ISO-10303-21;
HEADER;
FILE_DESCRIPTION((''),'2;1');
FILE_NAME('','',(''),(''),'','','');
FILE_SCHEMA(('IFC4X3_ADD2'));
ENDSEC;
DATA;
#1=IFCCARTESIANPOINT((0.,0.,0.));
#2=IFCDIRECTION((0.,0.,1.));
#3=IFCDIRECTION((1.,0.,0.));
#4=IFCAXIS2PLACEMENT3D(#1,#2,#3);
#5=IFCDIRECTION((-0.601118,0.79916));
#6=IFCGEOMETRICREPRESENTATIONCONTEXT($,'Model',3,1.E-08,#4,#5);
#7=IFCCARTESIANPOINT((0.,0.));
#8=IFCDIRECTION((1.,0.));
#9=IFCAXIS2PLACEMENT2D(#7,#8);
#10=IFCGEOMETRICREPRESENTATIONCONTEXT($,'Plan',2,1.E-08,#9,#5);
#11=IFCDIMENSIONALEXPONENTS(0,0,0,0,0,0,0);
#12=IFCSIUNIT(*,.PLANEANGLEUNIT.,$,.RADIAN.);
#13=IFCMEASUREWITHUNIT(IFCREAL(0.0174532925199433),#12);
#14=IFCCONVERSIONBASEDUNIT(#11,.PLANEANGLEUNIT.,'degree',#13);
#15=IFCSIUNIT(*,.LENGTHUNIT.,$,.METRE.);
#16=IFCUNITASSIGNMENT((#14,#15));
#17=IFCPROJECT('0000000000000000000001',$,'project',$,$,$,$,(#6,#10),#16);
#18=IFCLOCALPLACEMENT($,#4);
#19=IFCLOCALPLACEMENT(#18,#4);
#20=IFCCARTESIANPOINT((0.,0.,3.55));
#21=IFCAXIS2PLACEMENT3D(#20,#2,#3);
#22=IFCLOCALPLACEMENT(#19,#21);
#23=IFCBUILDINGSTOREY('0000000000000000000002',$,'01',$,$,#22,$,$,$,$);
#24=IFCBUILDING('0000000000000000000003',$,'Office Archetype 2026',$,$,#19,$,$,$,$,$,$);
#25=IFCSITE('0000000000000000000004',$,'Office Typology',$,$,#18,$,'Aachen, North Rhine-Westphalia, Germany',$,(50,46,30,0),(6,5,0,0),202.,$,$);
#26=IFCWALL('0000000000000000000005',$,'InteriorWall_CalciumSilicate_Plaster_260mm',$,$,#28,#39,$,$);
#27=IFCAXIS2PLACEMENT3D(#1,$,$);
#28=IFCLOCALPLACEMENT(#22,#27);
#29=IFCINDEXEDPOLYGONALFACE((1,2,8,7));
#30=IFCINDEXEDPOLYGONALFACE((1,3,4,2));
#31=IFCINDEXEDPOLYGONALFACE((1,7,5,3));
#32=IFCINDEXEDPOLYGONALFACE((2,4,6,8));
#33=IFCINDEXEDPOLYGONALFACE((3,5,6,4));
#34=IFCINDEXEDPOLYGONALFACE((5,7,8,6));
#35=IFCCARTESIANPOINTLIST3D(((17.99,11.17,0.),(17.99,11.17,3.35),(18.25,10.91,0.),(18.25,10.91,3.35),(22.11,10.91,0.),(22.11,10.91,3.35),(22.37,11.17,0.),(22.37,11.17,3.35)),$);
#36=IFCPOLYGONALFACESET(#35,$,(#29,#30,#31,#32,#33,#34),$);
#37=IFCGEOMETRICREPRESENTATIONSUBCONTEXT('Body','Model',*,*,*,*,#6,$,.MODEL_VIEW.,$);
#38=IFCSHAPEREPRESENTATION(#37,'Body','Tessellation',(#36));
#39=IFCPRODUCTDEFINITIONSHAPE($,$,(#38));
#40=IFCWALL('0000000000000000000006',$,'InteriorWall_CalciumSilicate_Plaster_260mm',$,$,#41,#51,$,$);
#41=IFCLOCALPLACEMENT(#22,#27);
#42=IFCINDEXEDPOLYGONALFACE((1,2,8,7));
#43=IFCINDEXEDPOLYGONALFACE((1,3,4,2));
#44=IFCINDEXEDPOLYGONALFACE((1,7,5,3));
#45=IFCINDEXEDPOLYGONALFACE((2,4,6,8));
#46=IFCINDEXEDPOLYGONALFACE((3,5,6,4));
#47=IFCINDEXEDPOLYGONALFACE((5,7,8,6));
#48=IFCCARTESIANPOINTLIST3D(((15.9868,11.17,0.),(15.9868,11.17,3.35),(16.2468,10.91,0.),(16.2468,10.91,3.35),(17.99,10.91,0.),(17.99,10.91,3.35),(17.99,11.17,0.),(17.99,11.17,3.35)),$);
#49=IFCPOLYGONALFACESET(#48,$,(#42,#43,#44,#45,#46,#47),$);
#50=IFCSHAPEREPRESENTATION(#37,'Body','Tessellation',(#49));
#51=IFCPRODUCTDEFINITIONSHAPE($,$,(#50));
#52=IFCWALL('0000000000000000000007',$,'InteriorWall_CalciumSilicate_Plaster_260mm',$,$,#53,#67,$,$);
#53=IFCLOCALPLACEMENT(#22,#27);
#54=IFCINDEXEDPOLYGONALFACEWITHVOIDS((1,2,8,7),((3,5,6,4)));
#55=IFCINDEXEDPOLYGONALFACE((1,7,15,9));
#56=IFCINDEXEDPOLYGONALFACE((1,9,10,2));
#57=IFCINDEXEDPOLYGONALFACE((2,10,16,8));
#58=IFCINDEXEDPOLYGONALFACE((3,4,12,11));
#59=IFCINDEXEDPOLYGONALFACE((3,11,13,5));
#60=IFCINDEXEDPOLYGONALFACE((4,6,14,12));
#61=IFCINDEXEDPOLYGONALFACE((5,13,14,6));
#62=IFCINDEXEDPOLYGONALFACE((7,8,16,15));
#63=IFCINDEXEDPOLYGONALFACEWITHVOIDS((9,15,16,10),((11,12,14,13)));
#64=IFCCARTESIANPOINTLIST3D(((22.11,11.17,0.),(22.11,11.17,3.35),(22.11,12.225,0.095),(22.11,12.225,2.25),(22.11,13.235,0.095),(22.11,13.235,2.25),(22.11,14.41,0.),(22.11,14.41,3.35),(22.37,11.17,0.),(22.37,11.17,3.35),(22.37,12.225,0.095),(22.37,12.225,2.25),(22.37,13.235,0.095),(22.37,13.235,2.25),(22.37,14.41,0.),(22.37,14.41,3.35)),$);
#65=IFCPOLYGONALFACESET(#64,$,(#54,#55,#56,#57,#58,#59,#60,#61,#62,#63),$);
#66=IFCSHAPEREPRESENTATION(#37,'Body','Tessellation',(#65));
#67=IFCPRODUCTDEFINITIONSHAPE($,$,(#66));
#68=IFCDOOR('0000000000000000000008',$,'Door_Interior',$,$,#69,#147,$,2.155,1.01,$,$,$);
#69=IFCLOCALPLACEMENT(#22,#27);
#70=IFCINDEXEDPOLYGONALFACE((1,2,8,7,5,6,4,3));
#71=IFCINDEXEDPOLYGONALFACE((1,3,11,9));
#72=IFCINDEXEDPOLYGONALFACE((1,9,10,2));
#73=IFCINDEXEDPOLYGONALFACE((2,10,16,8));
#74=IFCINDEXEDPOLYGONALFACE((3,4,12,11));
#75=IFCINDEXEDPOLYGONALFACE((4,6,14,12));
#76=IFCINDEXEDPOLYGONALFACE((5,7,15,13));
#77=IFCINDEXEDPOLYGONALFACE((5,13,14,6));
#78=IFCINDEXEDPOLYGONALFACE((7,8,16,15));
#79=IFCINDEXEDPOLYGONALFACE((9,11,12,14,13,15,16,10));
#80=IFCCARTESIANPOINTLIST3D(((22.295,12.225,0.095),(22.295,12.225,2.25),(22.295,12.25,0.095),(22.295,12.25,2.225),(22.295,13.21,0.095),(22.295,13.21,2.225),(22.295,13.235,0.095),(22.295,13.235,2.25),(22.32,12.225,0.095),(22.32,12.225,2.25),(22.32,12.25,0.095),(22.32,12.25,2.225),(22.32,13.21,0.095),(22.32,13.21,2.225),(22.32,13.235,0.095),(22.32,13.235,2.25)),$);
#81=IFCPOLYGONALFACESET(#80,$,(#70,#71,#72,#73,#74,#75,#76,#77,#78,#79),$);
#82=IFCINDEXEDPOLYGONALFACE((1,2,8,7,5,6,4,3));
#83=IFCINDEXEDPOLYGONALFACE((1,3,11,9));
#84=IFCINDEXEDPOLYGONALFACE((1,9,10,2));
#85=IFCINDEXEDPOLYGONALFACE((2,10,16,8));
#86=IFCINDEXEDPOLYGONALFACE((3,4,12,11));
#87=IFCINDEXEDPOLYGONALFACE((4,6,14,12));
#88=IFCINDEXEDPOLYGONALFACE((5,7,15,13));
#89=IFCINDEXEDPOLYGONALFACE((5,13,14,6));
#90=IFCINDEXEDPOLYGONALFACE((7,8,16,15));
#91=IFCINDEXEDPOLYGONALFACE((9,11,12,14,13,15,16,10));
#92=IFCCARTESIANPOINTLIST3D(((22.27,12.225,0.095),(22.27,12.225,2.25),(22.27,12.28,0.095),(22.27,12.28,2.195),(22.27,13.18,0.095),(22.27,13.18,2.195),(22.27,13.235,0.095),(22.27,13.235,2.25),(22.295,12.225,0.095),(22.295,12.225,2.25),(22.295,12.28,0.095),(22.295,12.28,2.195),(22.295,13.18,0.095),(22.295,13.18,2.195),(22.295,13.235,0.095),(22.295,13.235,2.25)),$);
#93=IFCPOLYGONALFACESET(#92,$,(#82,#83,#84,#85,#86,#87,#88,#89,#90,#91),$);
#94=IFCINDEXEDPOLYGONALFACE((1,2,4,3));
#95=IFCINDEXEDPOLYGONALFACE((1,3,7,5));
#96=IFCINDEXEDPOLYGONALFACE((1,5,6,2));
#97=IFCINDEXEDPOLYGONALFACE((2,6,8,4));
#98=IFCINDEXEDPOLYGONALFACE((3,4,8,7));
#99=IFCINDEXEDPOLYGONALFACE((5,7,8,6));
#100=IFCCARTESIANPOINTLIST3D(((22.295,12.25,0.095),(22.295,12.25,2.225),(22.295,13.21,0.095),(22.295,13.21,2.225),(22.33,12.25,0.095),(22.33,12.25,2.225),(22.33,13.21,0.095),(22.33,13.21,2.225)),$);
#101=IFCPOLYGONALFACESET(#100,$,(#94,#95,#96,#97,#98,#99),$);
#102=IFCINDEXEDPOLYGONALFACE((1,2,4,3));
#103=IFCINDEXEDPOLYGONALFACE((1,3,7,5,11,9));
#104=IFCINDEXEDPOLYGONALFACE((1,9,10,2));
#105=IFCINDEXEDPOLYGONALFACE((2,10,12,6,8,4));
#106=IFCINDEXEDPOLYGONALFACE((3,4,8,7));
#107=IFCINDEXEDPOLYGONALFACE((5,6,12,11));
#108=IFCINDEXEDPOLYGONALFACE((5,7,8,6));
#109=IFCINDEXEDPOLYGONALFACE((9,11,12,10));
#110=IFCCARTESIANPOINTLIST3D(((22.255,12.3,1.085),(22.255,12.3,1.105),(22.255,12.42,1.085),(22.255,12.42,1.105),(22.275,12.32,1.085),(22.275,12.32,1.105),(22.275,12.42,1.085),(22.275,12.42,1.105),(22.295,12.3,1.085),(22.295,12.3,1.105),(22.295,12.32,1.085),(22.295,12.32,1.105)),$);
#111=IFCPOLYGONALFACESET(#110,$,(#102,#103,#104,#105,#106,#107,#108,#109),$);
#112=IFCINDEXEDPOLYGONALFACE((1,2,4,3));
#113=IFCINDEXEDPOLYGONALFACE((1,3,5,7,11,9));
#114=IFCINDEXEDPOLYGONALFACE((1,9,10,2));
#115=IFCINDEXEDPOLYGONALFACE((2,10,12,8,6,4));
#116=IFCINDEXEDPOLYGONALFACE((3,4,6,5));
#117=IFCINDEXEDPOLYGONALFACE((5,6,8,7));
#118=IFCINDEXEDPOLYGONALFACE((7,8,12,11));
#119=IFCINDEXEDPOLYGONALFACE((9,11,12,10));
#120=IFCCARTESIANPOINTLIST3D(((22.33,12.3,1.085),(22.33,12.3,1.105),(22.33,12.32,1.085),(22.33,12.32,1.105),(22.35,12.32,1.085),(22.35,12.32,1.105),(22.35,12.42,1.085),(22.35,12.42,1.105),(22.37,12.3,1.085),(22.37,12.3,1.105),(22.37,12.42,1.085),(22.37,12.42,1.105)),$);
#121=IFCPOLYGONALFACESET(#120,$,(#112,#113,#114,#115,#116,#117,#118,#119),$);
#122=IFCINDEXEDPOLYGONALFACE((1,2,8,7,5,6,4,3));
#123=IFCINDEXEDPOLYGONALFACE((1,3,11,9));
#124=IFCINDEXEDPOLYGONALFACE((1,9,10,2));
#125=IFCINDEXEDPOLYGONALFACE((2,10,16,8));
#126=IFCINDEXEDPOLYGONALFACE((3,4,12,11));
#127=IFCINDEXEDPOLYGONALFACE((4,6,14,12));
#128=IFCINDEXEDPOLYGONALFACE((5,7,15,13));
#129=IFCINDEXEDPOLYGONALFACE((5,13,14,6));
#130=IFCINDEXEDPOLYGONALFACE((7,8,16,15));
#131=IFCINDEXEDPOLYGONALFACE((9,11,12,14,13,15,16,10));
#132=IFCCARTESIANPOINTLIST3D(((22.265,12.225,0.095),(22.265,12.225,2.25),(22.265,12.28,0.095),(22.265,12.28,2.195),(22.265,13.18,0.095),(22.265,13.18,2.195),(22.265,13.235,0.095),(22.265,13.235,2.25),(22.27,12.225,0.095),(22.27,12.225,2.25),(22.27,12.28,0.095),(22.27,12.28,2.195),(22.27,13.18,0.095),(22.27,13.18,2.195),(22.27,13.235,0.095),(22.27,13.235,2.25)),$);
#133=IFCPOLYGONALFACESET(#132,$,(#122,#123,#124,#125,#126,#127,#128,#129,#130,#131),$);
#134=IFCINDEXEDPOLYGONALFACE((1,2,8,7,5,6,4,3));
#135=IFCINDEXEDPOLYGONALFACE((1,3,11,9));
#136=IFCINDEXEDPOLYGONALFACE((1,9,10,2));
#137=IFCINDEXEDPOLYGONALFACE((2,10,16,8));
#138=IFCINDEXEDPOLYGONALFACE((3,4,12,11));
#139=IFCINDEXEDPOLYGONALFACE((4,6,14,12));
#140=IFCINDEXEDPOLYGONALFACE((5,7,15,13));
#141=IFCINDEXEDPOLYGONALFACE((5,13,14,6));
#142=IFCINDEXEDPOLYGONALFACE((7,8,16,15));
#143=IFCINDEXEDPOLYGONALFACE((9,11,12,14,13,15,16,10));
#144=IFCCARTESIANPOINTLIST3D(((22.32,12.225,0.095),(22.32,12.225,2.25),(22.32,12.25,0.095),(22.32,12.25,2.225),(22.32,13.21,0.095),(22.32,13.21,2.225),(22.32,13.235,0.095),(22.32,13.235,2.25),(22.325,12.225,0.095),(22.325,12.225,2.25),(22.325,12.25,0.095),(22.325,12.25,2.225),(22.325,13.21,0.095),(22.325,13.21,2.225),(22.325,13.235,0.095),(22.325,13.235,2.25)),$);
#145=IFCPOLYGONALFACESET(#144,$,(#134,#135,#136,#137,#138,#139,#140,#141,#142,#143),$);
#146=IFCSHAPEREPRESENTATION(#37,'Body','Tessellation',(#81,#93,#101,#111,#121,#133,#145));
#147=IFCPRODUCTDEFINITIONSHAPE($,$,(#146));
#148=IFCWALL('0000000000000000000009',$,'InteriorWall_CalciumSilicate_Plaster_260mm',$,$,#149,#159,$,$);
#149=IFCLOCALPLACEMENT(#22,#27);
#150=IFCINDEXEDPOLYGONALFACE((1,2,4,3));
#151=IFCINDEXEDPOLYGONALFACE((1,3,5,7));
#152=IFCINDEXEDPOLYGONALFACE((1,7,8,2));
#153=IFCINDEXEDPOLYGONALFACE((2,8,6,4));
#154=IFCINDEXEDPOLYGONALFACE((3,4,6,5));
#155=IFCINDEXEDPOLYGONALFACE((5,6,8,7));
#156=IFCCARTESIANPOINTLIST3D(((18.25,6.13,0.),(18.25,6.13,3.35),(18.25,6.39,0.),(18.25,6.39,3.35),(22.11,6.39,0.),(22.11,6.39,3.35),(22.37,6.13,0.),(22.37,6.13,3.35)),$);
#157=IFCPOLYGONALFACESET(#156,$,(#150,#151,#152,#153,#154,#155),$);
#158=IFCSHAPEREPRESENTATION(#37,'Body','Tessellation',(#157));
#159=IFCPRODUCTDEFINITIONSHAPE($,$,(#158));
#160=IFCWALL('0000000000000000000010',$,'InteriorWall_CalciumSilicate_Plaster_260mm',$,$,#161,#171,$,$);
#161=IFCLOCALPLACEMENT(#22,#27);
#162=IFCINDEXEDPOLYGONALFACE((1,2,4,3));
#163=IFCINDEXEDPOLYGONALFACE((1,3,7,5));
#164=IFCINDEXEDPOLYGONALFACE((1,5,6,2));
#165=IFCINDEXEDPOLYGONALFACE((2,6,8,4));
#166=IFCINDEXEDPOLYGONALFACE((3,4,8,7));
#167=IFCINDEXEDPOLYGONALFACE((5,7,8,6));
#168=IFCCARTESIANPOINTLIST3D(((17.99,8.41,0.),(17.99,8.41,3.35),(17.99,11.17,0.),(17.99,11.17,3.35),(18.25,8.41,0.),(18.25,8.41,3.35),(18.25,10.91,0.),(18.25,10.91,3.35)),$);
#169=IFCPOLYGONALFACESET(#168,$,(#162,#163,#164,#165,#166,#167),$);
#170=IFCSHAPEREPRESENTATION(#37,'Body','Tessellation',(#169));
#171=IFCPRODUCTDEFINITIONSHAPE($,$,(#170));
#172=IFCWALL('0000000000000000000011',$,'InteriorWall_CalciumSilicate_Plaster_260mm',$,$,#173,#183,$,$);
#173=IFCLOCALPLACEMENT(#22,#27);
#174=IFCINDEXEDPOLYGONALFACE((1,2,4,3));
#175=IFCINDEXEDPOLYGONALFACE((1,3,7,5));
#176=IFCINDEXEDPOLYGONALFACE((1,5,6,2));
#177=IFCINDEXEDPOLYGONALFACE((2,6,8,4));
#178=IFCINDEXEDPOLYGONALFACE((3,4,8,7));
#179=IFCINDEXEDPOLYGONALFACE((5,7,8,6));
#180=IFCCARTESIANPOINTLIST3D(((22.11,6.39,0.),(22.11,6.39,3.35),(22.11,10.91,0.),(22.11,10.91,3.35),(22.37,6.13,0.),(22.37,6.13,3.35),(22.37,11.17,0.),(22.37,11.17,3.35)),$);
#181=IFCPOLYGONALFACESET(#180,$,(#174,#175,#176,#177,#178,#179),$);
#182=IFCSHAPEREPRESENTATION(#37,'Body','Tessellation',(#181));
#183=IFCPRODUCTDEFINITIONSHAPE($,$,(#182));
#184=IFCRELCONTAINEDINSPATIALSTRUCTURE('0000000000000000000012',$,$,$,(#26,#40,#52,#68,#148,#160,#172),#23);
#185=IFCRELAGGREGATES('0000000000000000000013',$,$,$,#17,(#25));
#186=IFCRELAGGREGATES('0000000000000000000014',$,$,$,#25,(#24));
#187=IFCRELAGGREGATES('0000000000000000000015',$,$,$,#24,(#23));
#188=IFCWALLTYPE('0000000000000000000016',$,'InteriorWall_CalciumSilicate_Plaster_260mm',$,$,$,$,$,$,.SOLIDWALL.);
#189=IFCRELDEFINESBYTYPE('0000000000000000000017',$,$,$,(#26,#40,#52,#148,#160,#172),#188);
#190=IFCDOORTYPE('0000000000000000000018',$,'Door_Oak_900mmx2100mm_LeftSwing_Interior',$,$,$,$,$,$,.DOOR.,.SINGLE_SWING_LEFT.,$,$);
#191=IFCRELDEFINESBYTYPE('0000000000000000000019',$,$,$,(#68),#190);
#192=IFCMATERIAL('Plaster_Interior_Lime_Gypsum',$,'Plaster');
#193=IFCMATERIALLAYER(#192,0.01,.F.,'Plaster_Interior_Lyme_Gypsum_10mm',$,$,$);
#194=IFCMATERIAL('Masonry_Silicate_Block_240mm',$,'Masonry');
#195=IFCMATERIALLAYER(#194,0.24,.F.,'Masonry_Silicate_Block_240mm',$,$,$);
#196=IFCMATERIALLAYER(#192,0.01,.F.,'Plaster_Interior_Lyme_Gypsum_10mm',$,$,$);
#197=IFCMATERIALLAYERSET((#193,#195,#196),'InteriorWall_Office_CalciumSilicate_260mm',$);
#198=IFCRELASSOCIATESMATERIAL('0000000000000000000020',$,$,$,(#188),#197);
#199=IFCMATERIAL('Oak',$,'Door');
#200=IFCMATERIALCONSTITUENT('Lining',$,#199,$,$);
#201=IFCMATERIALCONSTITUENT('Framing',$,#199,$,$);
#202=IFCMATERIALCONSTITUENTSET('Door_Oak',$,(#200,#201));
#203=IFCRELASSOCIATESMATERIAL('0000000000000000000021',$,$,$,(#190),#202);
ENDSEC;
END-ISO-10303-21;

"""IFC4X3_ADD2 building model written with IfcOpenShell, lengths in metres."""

from ifc_helpers import new_model, entity, si_unit, converted_unit, direction, frame, origin_with_axes, origin_2d_with_axis, place, context, subcontext, project, spatial, line, indexed_curve, outline, extrude, source, transform, mapped, material, layer, layer_set, constituent, constituent_set, type_object, type_shapes, element, fill, save


model = new_model("IFC4X3_ADD2")

# Units and contexts
model_context = context("Model", 3, precision=1e-08, world=origin_with_axes(), true_north=direction((-0.601118, 0.79916)))
plan_context = context("Plan", 2, precision=1e-08, world=origin_2d_with_axis(), true_north=direction((-0.601118, 0.79916)))
body_context = subcontext(model_context, "Body", "Model", "MODEL_VIEW")
ifc_project = project(units=[converted_unit("PLANEANGLEUNIT", "degree", entity("IfcReal", 0.0174532925199433), si_unit("PLANEANGLEUNIT", "RADIAN"), dimensions=[0, 0, 0, 0, 0, 0, 0]), si_unit("LENGTHUNIT", "METRE")], contexts=[model_context, plan_context])

# Site, building, storey
site_placement = place(None, origin_with_axes())
site = spatial("IfcSite", under=ifc_project, at=site_placement, Name="Office Typology", LongName="Aachen, North Rhine-Westphalia, Germany", RefLatitude=(50, 46, 30, 0), RefLongitude=(6, 5, 0, 0), RefElevation=202.0)
building_placement = place(site_placement, origin_with_axes())
building = spatial("IfcBuilding", under=site, at=building_placement, Name="Office Archetype 2026")
storey_placement = place(building_placement, frame((0.0, 0.0, 3.55), z_axis=(0.0, 0.0, 1.0), x_axis=(1.0, 0.0, 0.0)))
storey = spatial("IfcBuildingStorey", under=building, at=storey_placement, Name="01")

# Shared definitions
ifc_material_1 = material(Name="Plaster_Interior_Lime_Gypsum", Category="Plaster")
ifc_layer_1 = layer(ifc_material_1, 0.01, ventilated=False, Name="Plaster_Interior_Lyme_Gypsum_10mm")
ifc_material_2 = material(Name="Masonry_Silicate_Block_240mm", Category="Masonry")
ifc_layer_2 = layer(ifc_material_2, 0.24, ventilated=False, Name="Masonry_Silicate_Block_240mm")
ifc_layer_3 = layer(ifc_material_1, 0.01, ventilated=False, Name="Plaster_Interior_Lyme_Gypsum_10mm")
ifc_layer_set_1 = layer_set([ifc_layer_1, ifc_layer_2, ifc_layer_3], Name="InteriorWall_Office_CalciumSilicate_260mm")
wall_type_1 = type_object("IfcWallType", Name="InteriorWall_CalciumSilicate_Plaster_260mm", PredefinedType="SOLIDWALL", material=ifc_layer_set_1)
ifc_material_3 = material(Name="Oak", Category="Door")

# Walls
wall_1_placement = place(storey_placement, frame((22.37, 11.17, 0.0), z_axis=(0.0, 0.0, 1.0), x_axis=(-1.0, 0.0, 0.0)))
element("IfcWall", 1, at=wall_1_placement, inside=storey, type_object=wall_type_1, Name="InteriorWall_CalciumSilicate_Plaster_260mm", context=body_context, shape_type="SweptSolid", body=[
    extrude(outline(indexed_curve([(0.0, 0.0), (0.26, 0.26), (4.12, 0.26), (4.38, 0.0)], segments=[line(1, 2, 3, 4, 1)])), origin_with_axes(), (0.0, 0.0, 1.0), 3.35),
])
wall_2_placement = place(storey_placement, frame((17.99, 11.17, 0.0), z_axis=(0.0, 0.0, 1.0), x_axis=(-1.0, 0.0, 0.0)))
element("IfcWall", 2, at=wall_2_placement, inside=storey, type_object=wall_type_1, Name="InteriorWall_CalciumSilicate_Plaster_260mm", context=body_context, shape_type="SweptSolid", body=[
    extrude(outline(indexed_curve([(0.0, 0.0), (0.0, 0.26), (1.7432, 0.26), (2.0032, 0.0)], segments=[line(1, 2, 3, 4, 1)])), origin_with_axes(), (0.0, 0.0, 1.0), 3.35),
])

# Wall, opening, door
wall_3_placement = place(storey_placement, frame((22.37, 11.17, 0.0), z_axis=(0.0, 0.0, 1.0), x_axis=(0.0, 1.0, 0.0)))
wall_3 = element("IfcWall", 3, at=wall_3_placement, inside=storey, type_object=wall_type_1, Name="InteriorWall_CalciumSilicate_Plaster_260mm", context=body_context, shape_type="SweptSolid", body=[
    extrude(outline(indexed_curve([(0.0, 0.0), (0.0, 0.26), (3.24, 0.26), (3.24, 0.0)], segments=[line(1, 2, 3, 4, 1)])), origin_with_axes(), (0.0, 0.0, 1.0), 3.35),
])
shared_shape_1 = source(origin_with_axes(), body_context, "Body", "SweptSolid", [
    extrude(outline(indexed_curve([(0.0, 2.155), (1.01, 2.155), (1.01, 0.0), (0.0, 0.0), (0.0, 2.155)])), frame((0.0, -0.015, 0.0), z_axis=(0.0, -1.0, 0.0), x_axis=(1.0, 0.0, 0.0)), (0.0, 0.0, -1.0), 0.26),
])
opening_1_placement = place(wall_3_placement, frame((2.065, 0.245, 0.095), z_axis=(0.0, 0.0, 1.0), x_axis=(-1.0, 0.0, 0.0)))
opening_1 = element("IfcOpeningElement", 4, at=opening_1_placement, cuts=wall_3, PredefinedType="OPENING", context=body_context, shape_type="MappedRepresentation", body=[
    mapped(shared_shape_1, transform((0.0, 0.0, 0.0), x_axis=(1.0, 0.0, 0.0), y_axis=(0.0, 1.0, 0.0), z_axis=(0.0, 0.0, 1.0), scale=1.0)),
])
ifc_constituent_1 = constituent(ifc_material_3, Name="Lining")
ifc_constituent_2 = constituent(ifc_material_3, Name="Framing")
ifc_constituent_set_1 = constituent_set(constituents=[ifc_constituent_1, ifc_constituent_2], Name="Door_Oak")
door_type_1 = type_object("IfcDoorType", Name="Door_Oak_900mmx2100mm_LeftSwing_Interior", OperationType="SINGLE_SWING_LEFT", PredefinedType="DOOR", material=ifc_constituent_set_1)
shared_shape_2 = source(origin_with_axes(), body_context, "Body", "SweptSolid", [
    extrude(outline(indexed_curve([(0.0, 0.0), (0.0, 2.155), (1.01, 2.155), (1.01, 0.0), (0.985, 0.0), (0.985, 2.13), (0.025, 2.13), (0.025, 0.0)], segments=[line(1, 2, 3, 4, 5, 6, 7, 8, 1)])), frame((0.0, 0.025, 0.0), z_axis=(0.0, -1.0, 0.0), x_axis=(1.0, 0.0, 0.0)), (0.0, 0.0, -1.0), 0.025),
    extrude(outline(indexed_curve([(0.0, 0.0), (0.0, 2.155), (1.01, 2.155), (1.01, 0.0), (0.955, 0.0), (0.955, 2.1), (0.055, 2.1), (0.055, 0.0)], segments=[line(1, 2, 3, 4, 5, 6, 7, 8, 1)])), frame((0.0, 0.0, 0.0), z_axis=(0.0, -1.0, 0.0), x_axis=(1.0, 0.0, 0.0)), (0.0, 0.0, -1.0), 0.025),
    extrude(outline(indexed_curve([(0.0, 0.0), (0.96, 0.0), (0.96, 0.035), (0.0, 0.035)], segments=[line(1, 2, 3, 4, 1)])), frame((0.025, 0.025, 0.0), z_axis=(0.0, 0.0, 1.0), x_axis=(1.0, 0.0, 0.0)), (0.0, 0.0, 1.0), 2.13),
    extrude(outline(indexed_curve([(0.0, 0.0), (0.0, -0.04), (-0.12, -0.04), (-0.12, -0.02), (-0.02, -0.02), (-0.02, 0.0)], segments=[line(1, 2, 3, 4, 5, 6, 1)])), frame((0.935, 0.025, 0.99), z_axis=(0.0, 0.0, 1.0), x_axis=(1.0, 0.0, 0.0)), (0.0, 0.0, 1.0), 0.02),
    extrude(outline(indexed_curve([(0.0, 0.0), (0.0, 0.04), (-0.12, 0.04), (-0.12, 0.02), (-0.02, 0.02), (-0.02, 0.0)], segments=[line(1, 2, 3, 4, 5, 6, 1)])), frame((0.935, 0.06, 0.99), z_axis=(0.0, 0.0, 1.0), x_axis=(1.0, 0.0, 0.0)), (0.0, 0.0, 1.0), 0.02),
    extrude(outline(indexed_curve([(0.0, 0.0), (0.0, 2.155), (1.01, 2.155), (1.01, 0.0), (0.955, 0.0), (0.955, 2.1), (0.055, 2.1), (0.055, 0.0)], segments=[line(1, 2, 3, 4, 5, 6, 7, 8, 1)])), frame((0.0, -0.005, 0.0), z_axis=(0.0, -1.0, 0.0), x_axis=(1.0, 0.0, 0.0)), (0.0, 0.0, -1.0), 0.005),
    extrude(outline(indexed_curve([(0.0, 0.0), (0.0, 2.155), (1.01, 2.155), (1.01, 0.0), (0.985, 0.0), (0.985, 2.13), (0.025, 2.13), (0.025, 0.0)], segments=[line(1, 2, 3, 4, 5, 6, 7, 8, 1)])), frame((0.0, 0.05, 0.0), z_axis=(0.0, -1.0, 0.0), x_axis=(1.0, 0.0, 0.0)), (0.0, 0.0, -1.0), 0.005),
])
type_shapes(door_type_1, [shared_shape_2])
door_1_placement = place(opening_1_placement, frame((0.0, 0.145, 0.0), z_axis=(0.0, 0.0, 1.0), x_axis=(1.0, 0.0, 0.0)))
door_1 = element("IfcDoor", 5, at=door_1_placement, inside=storey, type_object=door_type_1, Name="Door_Interior", OverallHeight=2.155, OverallWidth=1.01, context=body_context, shape_type="MappedRepresentation", body=[
    mapped(shared_shape_2, transform((0.0, 0.0, 0.0), x_axis=(1.0, 0.0, 0.0), y_axis=(0.0, 1.0, 0.0), z_axis=(0.0, 0.0, 1.0), scale=1.0)),
])
fill(opening_1, door_1)

# Walls
wall_4_placement = place(storey_placement, frame((18.25, 6.13, 0.0), z_axis=(0.0, 0.0, 1.0), x_axis=(1.0, 0.0, 0.0)))
element("IfcWall", 6, at=wall_4_placement, inside=storey, type_object=wall_type_1, Name="InteriorWall_CalciumSilicate_Plaster_260mm", context=body_context, shape_type="SweptSolid", body=[
    extrude(outline(indexed_curve([(0.0, 0.0), (0.0, 0.26), (3.86, 0.26), (4.12, 0.0)], segments=[line(1, 2, 3, 4, 1)])), origin_with_axes(), (0.0, 0.0, 1.0), 3.35),
])
wall_5_placement = place(storey_placement, frame((17.99, 11.17, 0.0), z_axis=(0.0, 0.0, 1.0), x_axis=(0.0, -1.0, 0.0)))
element("IfcWall", 7, at=wall_5_placement, inside=storey, type_object=wall_type_1, Name="InteriorWall_CalciumSilicate_Plaster_260mm", context=body_context, shape_type="SweptSolid", body=[
    extrude(outline(indexed_curve([(0.0, 0.0), (0.26, 0.26), (2.76, 0.26), (2.76, 0.0)], segments=[line(1, 2, 3, 4, 1)])), origin_with_axes(), (0.0, 0.0, 1.0), 3.35),
])
wall_6_placement = place(storey_placement, frame((22.37, 6.13, 0.0), z_axis=(0.0, 0.0, 1.0), x_axis=(0.0, 1.0, 0.0)))
element("IfcWall", 8, at=wall_6_placement, inside=storey, type_object=wall_type_1, Name="InteriorWall_CalciumSilicate_Plaster_260mm", context=body_context, shape_type="SweptSolid", body=[
    extrude(outline(indexed_curve([(0.0, 0.0), (0.26, 0.26), (4.78, 0.26), (5.04, 0.0)], segments=[line(1, 2, 3, 4, 1)])), origin_with_axes(), (0.0, 0.0, 1.0), 3.35),
])

save(model, "model.ifc")
